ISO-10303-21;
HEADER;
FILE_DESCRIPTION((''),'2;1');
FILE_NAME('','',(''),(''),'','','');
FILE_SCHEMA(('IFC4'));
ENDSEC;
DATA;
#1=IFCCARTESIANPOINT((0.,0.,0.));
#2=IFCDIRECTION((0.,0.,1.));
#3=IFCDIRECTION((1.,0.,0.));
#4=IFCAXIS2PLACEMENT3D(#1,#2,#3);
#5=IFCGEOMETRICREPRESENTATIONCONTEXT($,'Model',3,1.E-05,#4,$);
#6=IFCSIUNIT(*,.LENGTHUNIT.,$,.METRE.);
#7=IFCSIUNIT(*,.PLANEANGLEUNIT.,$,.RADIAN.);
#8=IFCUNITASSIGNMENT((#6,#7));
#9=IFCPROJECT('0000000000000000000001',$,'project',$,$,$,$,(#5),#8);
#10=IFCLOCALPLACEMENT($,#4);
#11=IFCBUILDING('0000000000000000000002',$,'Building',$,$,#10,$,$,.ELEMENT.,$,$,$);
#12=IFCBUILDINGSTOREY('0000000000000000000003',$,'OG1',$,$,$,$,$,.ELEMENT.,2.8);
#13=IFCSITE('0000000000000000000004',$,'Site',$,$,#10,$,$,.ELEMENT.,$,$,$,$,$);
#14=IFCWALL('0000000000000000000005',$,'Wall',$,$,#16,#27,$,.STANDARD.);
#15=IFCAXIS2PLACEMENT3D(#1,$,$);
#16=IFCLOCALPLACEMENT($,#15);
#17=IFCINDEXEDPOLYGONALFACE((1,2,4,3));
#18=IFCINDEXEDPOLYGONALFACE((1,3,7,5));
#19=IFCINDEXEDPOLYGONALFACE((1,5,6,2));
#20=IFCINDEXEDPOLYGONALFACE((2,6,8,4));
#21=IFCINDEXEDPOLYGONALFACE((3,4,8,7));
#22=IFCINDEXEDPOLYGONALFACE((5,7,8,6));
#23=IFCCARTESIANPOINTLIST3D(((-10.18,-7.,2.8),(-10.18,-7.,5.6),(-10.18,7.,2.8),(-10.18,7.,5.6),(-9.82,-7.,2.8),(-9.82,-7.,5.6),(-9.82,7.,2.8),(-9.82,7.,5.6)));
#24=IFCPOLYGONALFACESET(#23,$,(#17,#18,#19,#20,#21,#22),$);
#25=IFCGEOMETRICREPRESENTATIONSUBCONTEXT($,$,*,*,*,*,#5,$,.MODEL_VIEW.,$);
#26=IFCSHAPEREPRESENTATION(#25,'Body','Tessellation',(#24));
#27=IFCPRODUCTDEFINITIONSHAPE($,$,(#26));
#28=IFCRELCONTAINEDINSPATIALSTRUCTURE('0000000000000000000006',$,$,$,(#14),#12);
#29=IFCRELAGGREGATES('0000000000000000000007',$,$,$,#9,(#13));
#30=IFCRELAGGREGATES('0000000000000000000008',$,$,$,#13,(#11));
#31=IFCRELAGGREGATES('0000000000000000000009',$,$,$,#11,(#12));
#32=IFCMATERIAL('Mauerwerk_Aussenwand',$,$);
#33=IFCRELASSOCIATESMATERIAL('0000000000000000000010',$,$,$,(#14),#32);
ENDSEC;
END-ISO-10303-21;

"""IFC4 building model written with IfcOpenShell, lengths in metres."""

from ifc_helpers import new_model, si_unit, frame, frame_2d, origin, origin_with_axes, place, context, subcontext, project, spatial, rectangle, extrude, material, element, save


model = new_model("IFC4")

# Units and contexts
model_context = context("Model", 3, precision=1e-05, world=origin_with_axes())
sub_context = subcontext(model_context, None, None, "MODEL_VIEW")
ifc_project = project(units=[si_unit("LENGTHUNIT", "METRE"), si_unit("PLANEANGLEUNIT", "RADIAN")], contexts=[model_context])

# Site, building, storey
placement_1 = place(None, origin_with_axes())
site = spatial("IfcSite", under=ifc_project, at=placement_1, Name="Site", CompositionType="ELEMENT")
building = spatial("IfcBuilding", under=site, at=placement_1, Name="Building", CompositionType="ELEMENT")
storey = spatial("IfcBuildingStorey", under=building, Name="OG1", CompositionType="ELEMENT", Elevation=2.8)

# Wall
ifc_material = material(Name="Mauerwerk_Aussenwand")
placement_2 = place(None, origin_with_axes())
placement_3 = place(placement_2, frame((0.0, 0.0, 2.8)))
wall_placement = place(placement_3, frame((-10.0, 7.0, 0.0), x_axis=(0.0, -1.0, 0.0)))
element("IfcWall", 1, at=wall_placement, inside=storey, material=ifc_material, Name="Wall", PredefinedType="STANDARD", context=sub_context, shape_type="SweptSolid", body=[
    extrude(rectangle(XDim=14.0, YDim=0.36, at=frame_2d((7.0, 0.0))), origin(), (0.0, 0.0, 1.0), 2.8),
])

save(model, "model.ifc")
